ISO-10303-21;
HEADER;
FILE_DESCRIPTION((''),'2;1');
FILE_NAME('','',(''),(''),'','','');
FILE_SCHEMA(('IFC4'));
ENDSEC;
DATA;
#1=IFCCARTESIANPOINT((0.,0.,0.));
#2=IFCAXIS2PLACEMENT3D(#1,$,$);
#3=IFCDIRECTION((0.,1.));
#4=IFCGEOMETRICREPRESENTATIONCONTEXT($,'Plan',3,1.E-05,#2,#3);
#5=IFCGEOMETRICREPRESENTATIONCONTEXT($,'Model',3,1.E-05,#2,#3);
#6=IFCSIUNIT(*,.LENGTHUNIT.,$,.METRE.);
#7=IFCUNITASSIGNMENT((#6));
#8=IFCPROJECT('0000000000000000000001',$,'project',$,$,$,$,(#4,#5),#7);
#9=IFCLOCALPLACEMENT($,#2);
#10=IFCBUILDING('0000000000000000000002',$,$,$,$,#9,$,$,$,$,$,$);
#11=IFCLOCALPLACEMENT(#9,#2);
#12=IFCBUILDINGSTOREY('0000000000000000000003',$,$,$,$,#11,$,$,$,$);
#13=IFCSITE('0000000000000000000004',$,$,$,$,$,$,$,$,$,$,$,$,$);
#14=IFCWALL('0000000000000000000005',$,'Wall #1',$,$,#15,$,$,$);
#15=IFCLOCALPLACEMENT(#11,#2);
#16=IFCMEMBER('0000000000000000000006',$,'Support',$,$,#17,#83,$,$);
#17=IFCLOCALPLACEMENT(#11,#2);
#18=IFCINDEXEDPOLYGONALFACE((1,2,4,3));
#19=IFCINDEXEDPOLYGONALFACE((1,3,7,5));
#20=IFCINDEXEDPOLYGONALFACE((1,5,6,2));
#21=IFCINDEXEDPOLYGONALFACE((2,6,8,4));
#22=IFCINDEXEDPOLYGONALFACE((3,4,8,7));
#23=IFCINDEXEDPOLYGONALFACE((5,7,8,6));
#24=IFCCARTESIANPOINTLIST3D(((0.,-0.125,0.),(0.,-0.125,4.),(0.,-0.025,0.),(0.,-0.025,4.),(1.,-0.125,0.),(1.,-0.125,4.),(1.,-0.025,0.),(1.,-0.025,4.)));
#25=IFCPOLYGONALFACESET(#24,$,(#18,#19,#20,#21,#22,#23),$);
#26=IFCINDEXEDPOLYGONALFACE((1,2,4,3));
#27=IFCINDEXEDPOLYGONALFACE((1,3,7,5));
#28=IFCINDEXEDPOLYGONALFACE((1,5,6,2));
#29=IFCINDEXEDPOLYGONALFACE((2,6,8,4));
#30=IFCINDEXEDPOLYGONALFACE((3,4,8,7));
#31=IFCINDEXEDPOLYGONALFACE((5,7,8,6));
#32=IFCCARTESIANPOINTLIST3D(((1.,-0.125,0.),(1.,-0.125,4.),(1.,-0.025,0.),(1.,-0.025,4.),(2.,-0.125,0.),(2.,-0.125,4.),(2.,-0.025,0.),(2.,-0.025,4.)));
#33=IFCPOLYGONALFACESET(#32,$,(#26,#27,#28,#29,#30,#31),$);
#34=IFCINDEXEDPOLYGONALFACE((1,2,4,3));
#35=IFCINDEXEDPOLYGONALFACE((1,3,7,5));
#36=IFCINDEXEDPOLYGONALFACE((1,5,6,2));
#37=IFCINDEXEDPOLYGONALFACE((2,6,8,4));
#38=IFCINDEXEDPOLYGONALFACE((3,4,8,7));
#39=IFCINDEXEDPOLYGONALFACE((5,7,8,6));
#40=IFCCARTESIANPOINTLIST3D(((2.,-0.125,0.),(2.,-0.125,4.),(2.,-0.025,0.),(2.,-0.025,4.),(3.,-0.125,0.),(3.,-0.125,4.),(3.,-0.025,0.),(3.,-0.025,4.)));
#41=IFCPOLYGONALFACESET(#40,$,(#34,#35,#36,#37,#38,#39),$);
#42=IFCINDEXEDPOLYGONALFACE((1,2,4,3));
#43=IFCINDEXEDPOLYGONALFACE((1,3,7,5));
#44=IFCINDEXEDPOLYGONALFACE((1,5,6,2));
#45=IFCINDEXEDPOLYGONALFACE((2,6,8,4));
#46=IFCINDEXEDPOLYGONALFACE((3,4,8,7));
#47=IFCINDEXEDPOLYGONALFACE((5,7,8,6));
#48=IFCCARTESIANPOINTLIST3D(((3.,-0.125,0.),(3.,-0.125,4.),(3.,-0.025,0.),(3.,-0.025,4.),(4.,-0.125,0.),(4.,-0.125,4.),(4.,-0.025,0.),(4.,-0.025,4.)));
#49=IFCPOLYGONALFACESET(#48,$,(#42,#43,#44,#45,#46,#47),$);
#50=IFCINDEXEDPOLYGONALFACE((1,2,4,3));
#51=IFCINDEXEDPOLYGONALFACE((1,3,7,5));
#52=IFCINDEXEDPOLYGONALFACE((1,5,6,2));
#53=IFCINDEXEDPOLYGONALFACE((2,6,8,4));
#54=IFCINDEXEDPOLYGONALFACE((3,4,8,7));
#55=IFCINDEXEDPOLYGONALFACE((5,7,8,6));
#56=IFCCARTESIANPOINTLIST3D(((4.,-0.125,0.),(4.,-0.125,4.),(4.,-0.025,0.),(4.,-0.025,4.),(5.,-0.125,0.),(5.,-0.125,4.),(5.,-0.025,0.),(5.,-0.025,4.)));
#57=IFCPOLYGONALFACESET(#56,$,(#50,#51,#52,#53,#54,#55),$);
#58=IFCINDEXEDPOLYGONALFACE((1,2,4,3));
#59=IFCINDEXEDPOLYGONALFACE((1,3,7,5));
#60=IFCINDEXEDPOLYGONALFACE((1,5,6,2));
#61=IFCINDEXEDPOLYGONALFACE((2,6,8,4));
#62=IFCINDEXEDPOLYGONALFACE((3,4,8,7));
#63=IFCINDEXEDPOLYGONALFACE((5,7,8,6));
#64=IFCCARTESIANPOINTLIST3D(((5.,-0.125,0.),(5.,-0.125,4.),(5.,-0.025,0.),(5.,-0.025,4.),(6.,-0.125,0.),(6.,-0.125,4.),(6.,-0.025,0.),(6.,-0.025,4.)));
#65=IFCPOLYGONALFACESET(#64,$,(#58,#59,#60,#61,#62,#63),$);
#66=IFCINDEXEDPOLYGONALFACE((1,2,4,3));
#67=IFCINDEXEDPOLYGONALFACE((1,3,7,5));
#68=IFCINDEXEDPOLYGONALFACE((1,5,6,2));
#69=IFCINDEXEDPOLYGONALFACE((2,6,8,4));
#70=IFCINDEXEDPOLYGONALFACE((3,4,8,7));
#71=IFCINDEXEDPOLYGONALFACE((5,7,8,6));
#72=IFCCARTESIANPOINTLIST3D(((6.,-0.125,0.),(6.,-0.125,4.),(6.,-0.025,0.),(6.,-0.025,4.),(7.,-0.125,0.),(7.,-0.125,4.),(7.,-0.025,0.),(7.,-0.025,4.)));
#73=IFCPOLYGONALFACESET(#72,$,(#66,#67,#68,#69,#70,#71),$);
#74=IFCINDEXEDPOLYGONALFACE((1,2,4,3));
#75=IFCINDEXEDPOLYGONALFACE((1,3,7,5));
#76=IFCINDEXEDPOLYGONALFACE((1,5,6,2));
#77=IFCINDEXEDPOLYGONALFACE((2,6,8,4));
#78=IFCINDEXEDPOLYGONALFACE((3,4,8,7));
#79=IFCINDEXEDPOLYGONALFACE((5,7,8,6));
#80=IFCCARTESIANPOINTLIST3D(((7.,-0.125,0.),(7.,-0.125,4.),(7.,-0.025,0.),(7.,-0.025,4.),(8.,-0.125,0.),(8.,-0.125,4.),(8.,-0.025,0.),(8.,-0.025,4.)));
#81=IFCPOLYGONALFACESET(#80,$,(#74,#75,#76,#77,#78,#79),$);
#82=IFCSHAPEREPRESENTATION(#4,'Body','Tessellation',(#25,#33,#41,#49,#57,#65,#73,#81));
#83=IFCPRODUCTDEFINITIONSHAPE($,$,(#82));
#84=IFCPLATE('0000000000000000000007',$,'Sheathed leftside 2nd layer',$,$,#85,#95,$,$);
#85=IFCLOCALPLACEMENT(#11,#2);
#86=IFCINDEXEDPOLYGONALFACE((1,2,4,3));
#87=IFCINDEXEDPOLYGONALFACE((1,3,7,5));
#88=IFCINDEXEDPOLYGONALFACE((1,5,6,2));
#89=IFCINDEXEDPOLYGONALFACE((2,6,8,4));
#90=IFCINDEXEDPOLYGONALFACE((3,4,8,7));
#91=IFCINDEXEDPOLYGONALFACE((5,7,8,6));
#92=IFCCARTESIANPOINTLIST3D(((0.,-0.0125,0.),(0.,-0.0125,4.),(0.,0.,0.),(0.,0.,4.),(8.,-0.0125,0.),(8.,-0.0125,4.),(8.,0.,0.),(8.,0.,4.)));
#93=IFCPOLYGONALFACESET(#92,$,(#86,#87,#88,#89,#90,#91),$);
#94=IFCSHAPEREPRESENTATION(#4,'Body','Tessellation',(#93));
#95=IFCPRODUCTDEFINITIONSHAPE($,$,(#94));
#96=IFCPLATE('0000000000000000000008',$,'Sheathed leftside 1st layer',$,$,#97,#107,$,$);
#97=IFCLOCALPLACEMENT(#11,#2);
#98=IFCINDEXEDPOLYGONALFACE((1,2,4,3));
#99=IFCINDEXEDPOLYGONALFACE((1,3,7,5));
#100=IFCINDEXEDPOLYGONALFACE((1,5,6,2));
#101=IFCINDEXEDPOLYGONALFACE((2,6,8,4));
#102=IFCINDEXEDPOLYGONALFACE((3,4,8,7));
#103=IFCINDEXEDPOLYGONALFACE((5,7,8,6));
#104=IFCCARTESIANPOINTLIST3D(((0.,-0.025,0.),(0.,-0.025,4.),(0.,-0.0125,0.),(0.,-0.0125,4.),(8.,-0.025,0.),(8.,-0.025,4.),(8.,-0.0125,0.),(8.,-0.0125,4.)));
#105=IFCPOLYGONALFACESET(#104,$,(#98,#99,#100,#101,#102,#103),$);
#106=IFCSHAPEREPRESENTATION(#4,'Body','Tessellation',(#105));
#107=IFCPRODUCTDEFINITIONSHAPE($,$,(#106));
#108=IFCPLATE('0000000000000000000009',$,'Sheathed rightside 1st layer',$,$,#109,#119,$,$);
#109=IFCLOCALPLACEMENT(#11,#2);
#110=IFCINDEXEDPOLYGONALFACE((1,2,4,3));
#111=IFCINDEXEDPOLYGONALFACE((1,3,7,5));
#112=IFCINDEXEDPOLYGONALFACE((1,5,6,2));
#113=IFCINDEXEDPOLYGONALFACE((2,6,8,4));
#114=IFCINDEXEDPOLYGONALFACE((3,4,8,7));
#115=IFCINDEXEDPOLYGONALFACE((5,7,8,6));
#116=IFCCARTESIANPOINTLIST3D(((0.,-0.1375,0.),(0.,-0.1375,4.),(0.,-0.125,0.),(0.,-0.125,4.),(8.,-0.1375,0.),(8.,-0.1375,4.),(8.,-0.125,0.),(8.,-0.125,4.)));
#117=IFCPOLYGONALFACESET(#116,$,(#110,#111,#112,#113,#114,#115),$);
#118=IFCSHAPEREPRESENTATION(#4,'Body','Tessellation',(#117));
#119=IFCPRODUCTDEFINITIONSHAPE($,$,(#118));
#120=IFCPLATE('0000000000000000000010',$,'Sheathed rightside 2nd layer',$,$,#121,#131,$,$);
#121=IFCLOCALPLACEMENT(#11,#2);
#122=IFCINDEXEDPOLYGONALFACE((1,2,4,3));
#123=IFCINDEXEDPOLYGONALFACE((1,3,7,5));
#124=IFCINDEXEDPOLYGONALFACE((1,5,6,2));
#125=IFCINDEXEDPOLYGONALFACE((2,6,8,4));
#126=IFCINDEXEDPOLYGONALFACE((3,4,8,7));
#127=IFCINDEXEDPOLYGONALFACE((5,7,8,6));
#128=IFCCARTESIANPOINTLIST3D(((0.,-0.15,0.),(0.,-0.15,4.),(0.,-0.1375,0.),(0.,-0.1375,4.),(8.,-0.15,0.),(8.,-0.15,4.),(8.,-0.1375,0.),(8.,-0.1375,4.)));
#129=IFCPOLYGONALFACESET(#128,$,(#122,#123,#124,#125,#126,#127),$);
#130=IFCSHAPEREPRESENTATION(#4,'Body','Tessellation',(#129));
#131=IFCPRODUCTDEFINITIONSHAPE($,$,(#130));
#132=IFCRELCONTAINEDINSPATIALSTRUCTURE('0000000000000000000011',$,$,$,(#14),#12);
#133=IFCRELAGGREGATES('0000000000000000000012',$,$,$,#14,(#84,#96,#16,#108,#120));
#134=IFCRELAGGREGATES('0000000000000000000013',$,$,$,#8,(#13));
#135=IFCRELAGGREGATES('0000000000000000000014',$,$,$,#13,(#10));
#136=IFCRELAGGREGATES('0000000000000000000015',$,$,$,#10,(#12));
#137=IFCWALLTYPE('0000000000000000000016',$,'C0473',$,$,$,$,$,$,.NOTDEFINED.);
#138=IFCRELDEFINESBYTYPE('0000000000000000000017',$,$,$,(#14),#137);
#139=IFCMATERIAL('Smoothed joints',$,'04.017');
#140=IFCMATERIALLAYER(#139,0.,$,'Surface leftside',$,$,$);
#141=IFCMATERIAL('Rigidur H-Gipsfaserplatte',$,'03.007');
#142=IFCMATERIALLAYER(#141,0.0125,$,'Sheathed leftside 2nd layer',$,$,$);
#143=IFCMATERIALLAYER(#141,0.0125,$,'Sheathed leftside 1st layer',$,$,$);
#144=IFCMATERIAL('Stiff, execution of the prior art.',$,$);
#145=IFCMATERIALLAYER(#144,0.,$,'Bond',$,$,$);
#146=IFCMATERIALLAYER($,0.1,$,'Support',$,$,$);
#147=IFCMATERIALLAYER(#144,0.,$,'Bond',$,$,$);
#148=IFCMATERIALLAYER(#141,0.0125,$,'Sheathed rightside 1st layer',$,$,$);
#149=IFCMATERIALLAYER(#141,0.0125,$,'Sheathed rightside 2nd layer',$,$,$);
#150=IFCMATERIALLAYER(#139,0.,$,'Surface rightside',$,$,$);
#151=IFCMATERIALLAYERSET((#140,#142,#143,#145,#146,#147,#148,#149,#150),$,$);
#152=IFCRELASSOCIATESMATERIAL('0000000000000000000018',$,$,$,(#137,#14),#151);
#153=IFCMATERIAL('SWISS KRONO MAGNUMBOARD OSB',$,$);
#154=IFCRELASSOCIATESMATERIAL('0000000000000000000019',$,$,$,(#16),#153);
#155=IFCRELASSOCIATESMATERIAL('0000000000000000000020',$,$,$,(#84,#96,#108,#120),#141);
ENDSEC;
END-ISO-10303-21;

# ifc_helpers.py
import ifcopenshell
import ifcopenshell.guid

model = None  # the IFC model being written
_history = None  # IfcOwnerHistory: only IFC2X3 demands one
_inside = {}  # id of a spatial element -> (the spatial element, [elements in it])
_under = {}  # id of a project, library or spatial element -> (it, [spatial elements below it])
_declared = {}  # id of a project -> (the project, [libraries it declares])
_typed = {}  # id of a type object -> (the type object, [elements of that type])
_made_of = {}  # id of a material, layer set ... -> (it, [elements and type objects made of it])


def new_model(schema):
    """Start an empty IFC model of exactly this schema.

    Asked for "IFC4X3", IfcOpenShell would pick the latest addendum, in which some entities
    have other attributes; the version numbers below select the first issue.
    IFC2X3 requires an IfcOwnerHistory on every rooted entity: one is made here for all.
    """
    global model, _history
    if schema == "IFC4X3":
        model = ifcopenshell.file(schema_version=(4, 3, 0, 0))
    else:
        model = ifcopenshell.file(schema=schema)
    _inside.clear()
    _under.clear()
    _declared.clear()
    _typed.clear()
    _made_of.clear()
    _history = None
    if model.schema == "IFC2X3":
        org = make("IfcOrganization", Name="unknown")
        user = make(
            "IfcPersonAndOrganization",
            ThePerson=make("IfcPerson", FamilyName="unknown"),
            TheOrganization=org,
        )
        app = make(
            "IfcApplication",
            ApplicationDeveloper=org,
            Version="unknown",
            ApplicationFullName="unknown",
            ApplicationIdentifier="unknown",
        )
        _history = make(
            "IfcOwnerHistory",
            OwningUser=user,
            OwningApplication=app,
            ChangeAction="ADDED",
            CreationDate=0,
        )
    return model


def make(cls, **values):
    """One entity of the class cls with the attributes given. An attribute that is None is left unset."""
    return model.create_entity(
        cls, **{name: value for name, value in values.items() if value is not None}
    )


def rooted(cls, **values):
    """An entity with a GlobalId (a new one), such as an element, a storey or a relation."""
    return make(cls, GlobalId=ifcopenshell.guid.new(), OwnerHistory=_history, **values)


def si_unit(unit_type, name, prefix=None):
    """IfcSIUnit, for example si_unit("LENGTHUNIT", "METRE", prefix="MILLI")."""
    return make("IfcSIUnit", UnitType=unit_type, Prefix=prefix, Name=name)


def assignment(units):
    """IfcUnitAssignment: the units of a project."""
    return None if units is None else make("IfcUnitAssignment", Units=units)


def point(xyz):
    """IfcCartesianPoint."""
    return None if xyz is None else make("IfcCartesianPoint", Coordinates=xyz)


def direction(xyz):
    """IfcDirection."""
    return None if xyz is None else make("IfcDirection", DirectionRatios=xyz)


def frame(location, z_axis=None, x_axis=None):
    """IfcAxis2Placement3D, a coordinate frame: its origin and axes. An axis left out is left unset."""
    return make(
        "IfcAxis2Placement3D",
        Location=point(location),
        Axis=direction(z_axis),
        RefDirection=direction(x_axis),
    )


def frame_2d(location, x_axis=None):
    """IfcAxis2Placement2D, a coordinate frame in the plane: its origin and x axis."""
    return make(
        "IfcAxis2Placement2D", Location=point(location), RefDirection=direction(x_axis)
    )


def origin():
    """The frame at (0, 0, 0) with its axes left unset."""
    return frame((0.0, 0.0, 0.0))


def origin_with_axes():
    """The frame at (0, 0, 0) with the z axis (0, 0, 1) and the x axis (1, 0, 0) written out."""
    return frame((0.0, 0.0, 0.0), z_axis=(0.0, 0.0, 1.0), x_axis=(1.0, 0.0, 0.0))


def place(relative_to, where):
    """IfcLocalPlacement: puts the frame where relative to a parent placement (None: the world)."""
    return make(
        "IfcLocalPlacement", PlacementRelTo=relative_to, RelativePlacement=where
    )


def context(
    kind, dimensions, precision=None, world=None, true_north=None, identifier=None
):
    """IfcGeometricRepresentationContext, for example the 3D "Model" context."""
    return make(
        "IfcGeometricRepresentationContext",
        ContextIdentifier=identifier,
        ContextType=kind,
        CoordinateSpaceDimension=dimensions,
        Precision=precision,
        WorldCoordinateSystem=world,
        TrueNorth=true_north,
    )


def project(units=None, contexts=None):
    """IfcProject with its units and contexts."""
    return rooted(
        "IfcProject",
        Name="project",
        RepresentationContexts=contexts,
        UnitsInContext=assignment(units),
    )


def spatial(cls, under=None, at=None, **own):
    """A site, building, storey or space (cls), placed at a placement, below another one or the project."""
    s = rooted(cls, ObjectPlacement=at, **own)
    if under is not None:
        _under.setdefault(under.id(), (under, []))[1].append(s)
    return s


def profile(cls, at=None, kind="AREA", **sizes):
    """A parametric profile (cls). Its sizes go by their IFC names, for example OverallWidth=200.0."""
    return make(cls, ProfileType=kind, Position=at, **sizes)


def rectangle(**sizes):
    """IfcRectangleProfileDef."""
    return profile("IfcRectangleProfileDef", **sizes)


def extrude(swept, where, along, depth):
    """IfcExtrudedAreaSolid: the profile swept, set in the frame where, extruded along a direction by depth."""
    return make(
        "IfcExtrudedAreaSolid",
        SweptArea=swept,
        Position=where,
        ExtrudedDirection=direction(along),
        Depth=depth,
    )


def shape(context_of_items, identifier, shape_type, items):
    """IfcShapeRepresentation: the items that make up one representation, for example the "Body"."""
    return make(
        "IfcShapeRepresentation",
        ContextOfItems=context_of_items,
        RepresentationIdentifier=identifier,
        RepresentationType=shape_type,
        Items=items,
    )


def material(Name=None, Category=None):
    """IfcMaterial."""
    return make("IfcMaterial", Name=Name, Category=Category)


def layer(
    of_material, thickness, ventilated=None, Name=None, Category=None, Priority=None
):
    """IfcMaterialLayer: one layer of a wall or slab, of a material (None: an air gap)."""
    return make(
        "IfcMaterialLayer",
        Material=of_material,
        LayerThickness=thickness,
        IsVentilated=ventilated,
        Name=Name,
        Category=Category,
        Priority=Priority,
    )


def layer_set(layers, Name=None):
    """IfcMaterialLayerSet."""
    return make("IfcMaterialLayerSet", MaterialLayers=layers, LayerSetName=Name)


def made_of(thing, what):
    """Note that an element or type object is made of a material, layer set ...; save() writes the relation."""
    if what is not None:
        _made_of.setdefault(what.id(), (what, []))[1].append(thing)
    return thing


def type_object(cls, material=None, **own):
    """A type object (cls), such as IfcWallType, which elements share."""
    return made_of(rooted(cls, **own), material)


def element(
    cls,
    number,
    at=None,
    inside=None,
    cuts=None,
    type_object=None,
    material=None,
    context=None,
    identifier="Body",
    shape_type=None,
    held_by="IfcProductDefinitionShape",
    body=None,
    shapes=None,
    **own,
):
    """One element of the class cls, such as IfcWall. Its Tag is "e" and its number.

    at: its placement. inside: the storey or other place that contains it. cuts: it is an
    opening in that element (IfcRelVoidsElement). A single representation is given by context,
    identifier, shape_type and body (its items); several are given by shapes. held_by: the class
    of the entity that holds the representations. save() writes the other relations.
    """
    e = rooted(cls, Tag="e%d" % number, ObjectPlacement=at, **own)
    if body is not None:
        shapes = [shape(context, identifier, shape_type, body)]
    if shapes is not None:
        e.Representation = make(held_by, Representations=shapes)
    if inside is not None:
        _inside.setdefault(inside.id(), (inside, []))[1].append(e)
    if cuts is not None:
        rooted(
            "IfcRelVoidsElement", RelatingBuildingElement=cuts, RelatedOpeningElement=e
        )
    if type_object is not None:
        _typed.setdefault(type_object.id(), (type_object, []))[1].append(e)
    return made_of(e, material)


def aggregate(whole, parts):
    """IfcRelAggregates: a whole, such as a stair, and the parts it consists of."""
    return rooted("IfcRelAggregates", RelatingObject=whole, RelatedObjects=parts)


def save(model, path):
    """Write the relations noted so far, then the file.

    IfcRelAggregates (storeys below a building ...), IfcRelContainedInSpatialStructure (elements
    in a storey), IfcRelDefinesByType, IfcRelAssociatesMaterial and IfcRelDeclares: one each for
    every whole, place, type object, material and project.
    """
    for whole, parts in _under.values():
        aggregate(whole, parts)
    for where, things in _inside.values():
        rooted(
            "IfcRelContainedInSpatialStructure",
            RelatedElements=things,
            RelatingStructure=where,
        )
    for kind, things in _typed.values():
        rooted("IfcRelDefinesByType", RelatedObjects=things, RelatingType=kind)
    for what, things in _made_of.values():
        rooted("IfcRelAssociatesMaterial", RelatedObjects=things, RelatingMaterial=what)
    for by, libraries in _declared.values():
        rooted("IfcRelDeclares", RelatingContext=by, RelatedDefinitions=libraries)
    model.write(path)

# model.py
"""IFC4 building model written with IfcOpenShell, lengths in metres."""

from ifc_helpers import new_model, si_unit, direction, frame, frame_2d, origin, origin_with_axes, place, context, project, spatial, rectangle, extrude, material, layer, layer_set, type_object, element, aggregate, save


model = new_model("IFC4")

# Units and contexts
plan_context = context("Plan", 3, precision=1e-05, world=origin(), true_north=direction((0.0, 1.0)))
model_context = context("Model", 3, precision=1e-05, world=origin(), true_north=direction((0.0, 1.0)))
ifc_project = project(units=[si_unit("LENGTHUNIT", "METRE")], contexts=[plan_context, model_context])

# Site, building, storey
site = spatial("IfcSite", under=ifc_project)
building_placement = place(None, origin())
building = spatial("IfcBuilding", under=site, at=building_placement)
storey_placement = place(building_placement, origin())
storey = spatial("IfcBuildingStorey", under=building, at=storey_placement)

# Wall, member, plates
ifc_material_1 = material(Name="Smoothed joints", Category="04.017")
ifc_layer_1 = layer(ifc_material_1, 0.0, Name="Surface leftside")
ifc_material_2 = material(Name="Rigidur H-Gipsfaserplatte", Category="03.007")
ifc_layer_2 = layer(ifc_material_2, 0.0125, Name="Sheathed leftside 2nd layer")
ifc_layer_3 = layer(ifc_material_2, 0.0125, Name="Sheathed leftside 1st layer")
ifc_material_3 = material(Name="Stiff, execution of the prior art.")
ifc_layer_4 = layer(ifc_material_3, 0.0, Name="Bond")
ifc_layer_5 = layer(None, 0.1, Name="Support")
ifc_layer_6 = layer(ifc_material_3, 0.0, Name="Bond")
ifc_layer_7 = layer(ifc_material_2, 0.0125, Name="Sheathed rightside 1st layer")
ifc_layer_8 = layer(ifc_material_2, 0.0125, Name="Sheathed rightside 2nd layer")
ifc_layer_9 = layer(ifc_material_1, 0.0, Name="Surface rightside")
ifc_layer_set = layer_set([ifc_layer_1, ifc_layer_2, ifc_layer_3, ifc_layer_4, ifc_layer_5, ifc_layer_6, ifc_layer_7, ifc_layer_8, ifc_layer_9])
wall_type = type_object("IfcWallType", Name="C0473", PredefinedType="NOTDEFINED", material=ifc_layer_set)
wall_placement = place(None, frame((0.0, 0.0, 0.0), z_axis=(0.0, -1.0, 0.0), x_axis=(1.0, 0.0, 0.0)))
wall = element("IfcWall", 1, at=wall_placement, inside=storey, type_object=wall_type, material=ifc_layer_set, Name="Wall #1")
ifc_material_4 = material(Name="SWISS KRONO MAGNUMBOARD OSB")
member_placement = place(wall_placement, origin())
member = element("IfcMember", 2, at=member_placement, material=ifc_material_4, Name="Support", context=plan_context, shape_type="SweptSolid", body=[
    extrude(rectangle(XDim=1.0, YDim=0.1, at=frame_2d((0.5, 0.05), x_axis=(1.0, 0.0))), frame((0.0, 4.0, 0.025), z_axis=(0.0, -1.0, 0.0), x_axis=(1.0, 0.0, 0.0)), (0.0, 0.0, 1.0), 4.0),
    extrude(rectangle(XDim=1.0, YDim=0.1, at=frame_2d((0.5, 0.05), x_axis=(1.0, 0.0))), frame((1.0, 4.0, 0.025), z_axis=(0.0, -1.0, 0.0), x_axis=(1.0, 0.0, 0.0)), (0.0, 0.0, 1.0), 4.0),
    extrude(rectangle(XDim=1.0, YDim=0.1, at=frame_2d((0.5, 0.05), x_axis=(1.0, 0.0))), frame((2.0, 4.0, 0.025), z_axis=(0.0, -1.0, 0.0), x_axis=(1.0, 0.0, 0.0)), (0.0, 0.0, 1.0), 4.0),
    extrude(rectangle(XDim=1.0, YDim=0.1, at=frame_2d((0.5, 0.05), x_axis=(1.0, 0.0))), frame((3.0, 4.0, 0.025), z_axis=(0.0, -1.0, 0.0), x_axis=(1.0, 0.0, 0.0)), (0.0, 0.0, 1.0), 4.0),
    extrude(rectangle(XDim=1.0, YDim=0.1, at=frame_2d((0.5, 0.05), x_axis=(1.0, 0.0))), frame((4.0, 4.0, 0.025), z_axis=(0.0, -1.0, 0.0), x_axis=(1.0, 0.0, 0.0)), (0.0, 0.0, 1.0), 4.0),
    extrude(rectangle(XDim=1.0, YDim=0.1, at=frame_2d((0.5, 0.05), x_axis=(1.0, 0.0))), frame((5.0, 4.0, 0.025), z_axis=(0.0, -1.0, 0.0), x_axis=(1.0, 0.0, 0.0)), (0.0, 0.0, 1.0), 4.0),
    extrude(rectangle(XDim=1.0, YDim=0.1, at=frame_2d((0.5, 0.05), x_axis=(1.0, 0.0))), frame((6.0, 4.0, 0.025), z_axis=(0.0, -1.0, 0.0), x_axis=(1.0, 0.0, 0.0)), (0.0, 0.0, 1.0), 4.0),
    extrude(rectangle(XDim=1.0, YDim=0.1, at=frame_2d((0.5, 0.05), x_axis=(1.0, 0.0))), frame((7.0, 4.0, 0.025), z_axis=(0.0, -1.0, 0.0), x_axis=(1.0, 0.0, 0.0)), (0.0, 0.0, 1.0), 4.0),
])
plate_1_placement = place(wall_placement, origin())
plate_1 = element("IfcPlate", 3, at=plate_1_placement, material=ifc_material_2, Name="Sheathed leftside 2nd layer", context=plan_context, shape_type="SweptSolid", body=[
    extrude(rectangle(XDim=8.0, YDim=4.0, at=frame_2d((4.0, 2.0), x_axis=(1.0, 0.0))), origin_with_axes(), (0.0, 0.0, 1.0), 0.0125),
])
plate_2_placement = place(wall_placement, origin())
plate_2 = element("IfcPlate", 4, at=plate_2_placement, material=ifc_material_2, Name="Sheathed leftside 1st layer", context=plan_context, shape_type="SweptSolid", body=[
    extrude(rectangle(XDim=8.0, YDim=4.0, at=frame_2d((4.0, 2.0), x_axis=(1.0, 0.0))), frame((0.0, 0.0, 0.0125), z_axis=(0.0, 0.0, 1.0), x_axis=(1.0, 0.0, 0.0)), (0.0, 0.0, 1.0), 0.0125),
])
plate_3_placement = place(wall_placement, origin())
plate_3 = element("IfcPlate", 5, at=plate_3_placement, material=ifc_material_2, Name="Sheathed rightside 1st layer", context=plan_context, shape_type="SweptSolid", body=[
    extrude(rectangle(XDim=8.0, YDim=4.0, at=frame_2d((4.0, 2.0), x_axis=(1.0, 0.0))), frame((0.0, 0.0, 0.125), z_axis=(0.0, 0.0, 1.0), x_axis=(1.0, 0.0, 0.0)), (0.0, 0.0, 1.0), 0.0125),
])
plate_4_placement = place(wall_placement, origin())
plate_4 = element("IfcPlate", 6, at=plate_4_placement, material=ifc_material_2, Name="Sheathed rightside 2nd layer", context=plan_context, shape_type="SweptSolid", body=[
    extrude(rectangle(XDim=8.0, YDim=4.0, at=frame_2d((4.0, 2.0), x_axis=(1.0, 0.0))), frame((0.0, 0.0, 0.1375), z_axis=(0.0, 0.0, 1.0), x_axis=(1.0, 0.0, 0.0)), (0.0, 0.0, 1.0), 0.0125),
])
aggregate(wall, [plate_1, plate_2, member, plate_3, plate_4])

save(model, "model.ifc")
